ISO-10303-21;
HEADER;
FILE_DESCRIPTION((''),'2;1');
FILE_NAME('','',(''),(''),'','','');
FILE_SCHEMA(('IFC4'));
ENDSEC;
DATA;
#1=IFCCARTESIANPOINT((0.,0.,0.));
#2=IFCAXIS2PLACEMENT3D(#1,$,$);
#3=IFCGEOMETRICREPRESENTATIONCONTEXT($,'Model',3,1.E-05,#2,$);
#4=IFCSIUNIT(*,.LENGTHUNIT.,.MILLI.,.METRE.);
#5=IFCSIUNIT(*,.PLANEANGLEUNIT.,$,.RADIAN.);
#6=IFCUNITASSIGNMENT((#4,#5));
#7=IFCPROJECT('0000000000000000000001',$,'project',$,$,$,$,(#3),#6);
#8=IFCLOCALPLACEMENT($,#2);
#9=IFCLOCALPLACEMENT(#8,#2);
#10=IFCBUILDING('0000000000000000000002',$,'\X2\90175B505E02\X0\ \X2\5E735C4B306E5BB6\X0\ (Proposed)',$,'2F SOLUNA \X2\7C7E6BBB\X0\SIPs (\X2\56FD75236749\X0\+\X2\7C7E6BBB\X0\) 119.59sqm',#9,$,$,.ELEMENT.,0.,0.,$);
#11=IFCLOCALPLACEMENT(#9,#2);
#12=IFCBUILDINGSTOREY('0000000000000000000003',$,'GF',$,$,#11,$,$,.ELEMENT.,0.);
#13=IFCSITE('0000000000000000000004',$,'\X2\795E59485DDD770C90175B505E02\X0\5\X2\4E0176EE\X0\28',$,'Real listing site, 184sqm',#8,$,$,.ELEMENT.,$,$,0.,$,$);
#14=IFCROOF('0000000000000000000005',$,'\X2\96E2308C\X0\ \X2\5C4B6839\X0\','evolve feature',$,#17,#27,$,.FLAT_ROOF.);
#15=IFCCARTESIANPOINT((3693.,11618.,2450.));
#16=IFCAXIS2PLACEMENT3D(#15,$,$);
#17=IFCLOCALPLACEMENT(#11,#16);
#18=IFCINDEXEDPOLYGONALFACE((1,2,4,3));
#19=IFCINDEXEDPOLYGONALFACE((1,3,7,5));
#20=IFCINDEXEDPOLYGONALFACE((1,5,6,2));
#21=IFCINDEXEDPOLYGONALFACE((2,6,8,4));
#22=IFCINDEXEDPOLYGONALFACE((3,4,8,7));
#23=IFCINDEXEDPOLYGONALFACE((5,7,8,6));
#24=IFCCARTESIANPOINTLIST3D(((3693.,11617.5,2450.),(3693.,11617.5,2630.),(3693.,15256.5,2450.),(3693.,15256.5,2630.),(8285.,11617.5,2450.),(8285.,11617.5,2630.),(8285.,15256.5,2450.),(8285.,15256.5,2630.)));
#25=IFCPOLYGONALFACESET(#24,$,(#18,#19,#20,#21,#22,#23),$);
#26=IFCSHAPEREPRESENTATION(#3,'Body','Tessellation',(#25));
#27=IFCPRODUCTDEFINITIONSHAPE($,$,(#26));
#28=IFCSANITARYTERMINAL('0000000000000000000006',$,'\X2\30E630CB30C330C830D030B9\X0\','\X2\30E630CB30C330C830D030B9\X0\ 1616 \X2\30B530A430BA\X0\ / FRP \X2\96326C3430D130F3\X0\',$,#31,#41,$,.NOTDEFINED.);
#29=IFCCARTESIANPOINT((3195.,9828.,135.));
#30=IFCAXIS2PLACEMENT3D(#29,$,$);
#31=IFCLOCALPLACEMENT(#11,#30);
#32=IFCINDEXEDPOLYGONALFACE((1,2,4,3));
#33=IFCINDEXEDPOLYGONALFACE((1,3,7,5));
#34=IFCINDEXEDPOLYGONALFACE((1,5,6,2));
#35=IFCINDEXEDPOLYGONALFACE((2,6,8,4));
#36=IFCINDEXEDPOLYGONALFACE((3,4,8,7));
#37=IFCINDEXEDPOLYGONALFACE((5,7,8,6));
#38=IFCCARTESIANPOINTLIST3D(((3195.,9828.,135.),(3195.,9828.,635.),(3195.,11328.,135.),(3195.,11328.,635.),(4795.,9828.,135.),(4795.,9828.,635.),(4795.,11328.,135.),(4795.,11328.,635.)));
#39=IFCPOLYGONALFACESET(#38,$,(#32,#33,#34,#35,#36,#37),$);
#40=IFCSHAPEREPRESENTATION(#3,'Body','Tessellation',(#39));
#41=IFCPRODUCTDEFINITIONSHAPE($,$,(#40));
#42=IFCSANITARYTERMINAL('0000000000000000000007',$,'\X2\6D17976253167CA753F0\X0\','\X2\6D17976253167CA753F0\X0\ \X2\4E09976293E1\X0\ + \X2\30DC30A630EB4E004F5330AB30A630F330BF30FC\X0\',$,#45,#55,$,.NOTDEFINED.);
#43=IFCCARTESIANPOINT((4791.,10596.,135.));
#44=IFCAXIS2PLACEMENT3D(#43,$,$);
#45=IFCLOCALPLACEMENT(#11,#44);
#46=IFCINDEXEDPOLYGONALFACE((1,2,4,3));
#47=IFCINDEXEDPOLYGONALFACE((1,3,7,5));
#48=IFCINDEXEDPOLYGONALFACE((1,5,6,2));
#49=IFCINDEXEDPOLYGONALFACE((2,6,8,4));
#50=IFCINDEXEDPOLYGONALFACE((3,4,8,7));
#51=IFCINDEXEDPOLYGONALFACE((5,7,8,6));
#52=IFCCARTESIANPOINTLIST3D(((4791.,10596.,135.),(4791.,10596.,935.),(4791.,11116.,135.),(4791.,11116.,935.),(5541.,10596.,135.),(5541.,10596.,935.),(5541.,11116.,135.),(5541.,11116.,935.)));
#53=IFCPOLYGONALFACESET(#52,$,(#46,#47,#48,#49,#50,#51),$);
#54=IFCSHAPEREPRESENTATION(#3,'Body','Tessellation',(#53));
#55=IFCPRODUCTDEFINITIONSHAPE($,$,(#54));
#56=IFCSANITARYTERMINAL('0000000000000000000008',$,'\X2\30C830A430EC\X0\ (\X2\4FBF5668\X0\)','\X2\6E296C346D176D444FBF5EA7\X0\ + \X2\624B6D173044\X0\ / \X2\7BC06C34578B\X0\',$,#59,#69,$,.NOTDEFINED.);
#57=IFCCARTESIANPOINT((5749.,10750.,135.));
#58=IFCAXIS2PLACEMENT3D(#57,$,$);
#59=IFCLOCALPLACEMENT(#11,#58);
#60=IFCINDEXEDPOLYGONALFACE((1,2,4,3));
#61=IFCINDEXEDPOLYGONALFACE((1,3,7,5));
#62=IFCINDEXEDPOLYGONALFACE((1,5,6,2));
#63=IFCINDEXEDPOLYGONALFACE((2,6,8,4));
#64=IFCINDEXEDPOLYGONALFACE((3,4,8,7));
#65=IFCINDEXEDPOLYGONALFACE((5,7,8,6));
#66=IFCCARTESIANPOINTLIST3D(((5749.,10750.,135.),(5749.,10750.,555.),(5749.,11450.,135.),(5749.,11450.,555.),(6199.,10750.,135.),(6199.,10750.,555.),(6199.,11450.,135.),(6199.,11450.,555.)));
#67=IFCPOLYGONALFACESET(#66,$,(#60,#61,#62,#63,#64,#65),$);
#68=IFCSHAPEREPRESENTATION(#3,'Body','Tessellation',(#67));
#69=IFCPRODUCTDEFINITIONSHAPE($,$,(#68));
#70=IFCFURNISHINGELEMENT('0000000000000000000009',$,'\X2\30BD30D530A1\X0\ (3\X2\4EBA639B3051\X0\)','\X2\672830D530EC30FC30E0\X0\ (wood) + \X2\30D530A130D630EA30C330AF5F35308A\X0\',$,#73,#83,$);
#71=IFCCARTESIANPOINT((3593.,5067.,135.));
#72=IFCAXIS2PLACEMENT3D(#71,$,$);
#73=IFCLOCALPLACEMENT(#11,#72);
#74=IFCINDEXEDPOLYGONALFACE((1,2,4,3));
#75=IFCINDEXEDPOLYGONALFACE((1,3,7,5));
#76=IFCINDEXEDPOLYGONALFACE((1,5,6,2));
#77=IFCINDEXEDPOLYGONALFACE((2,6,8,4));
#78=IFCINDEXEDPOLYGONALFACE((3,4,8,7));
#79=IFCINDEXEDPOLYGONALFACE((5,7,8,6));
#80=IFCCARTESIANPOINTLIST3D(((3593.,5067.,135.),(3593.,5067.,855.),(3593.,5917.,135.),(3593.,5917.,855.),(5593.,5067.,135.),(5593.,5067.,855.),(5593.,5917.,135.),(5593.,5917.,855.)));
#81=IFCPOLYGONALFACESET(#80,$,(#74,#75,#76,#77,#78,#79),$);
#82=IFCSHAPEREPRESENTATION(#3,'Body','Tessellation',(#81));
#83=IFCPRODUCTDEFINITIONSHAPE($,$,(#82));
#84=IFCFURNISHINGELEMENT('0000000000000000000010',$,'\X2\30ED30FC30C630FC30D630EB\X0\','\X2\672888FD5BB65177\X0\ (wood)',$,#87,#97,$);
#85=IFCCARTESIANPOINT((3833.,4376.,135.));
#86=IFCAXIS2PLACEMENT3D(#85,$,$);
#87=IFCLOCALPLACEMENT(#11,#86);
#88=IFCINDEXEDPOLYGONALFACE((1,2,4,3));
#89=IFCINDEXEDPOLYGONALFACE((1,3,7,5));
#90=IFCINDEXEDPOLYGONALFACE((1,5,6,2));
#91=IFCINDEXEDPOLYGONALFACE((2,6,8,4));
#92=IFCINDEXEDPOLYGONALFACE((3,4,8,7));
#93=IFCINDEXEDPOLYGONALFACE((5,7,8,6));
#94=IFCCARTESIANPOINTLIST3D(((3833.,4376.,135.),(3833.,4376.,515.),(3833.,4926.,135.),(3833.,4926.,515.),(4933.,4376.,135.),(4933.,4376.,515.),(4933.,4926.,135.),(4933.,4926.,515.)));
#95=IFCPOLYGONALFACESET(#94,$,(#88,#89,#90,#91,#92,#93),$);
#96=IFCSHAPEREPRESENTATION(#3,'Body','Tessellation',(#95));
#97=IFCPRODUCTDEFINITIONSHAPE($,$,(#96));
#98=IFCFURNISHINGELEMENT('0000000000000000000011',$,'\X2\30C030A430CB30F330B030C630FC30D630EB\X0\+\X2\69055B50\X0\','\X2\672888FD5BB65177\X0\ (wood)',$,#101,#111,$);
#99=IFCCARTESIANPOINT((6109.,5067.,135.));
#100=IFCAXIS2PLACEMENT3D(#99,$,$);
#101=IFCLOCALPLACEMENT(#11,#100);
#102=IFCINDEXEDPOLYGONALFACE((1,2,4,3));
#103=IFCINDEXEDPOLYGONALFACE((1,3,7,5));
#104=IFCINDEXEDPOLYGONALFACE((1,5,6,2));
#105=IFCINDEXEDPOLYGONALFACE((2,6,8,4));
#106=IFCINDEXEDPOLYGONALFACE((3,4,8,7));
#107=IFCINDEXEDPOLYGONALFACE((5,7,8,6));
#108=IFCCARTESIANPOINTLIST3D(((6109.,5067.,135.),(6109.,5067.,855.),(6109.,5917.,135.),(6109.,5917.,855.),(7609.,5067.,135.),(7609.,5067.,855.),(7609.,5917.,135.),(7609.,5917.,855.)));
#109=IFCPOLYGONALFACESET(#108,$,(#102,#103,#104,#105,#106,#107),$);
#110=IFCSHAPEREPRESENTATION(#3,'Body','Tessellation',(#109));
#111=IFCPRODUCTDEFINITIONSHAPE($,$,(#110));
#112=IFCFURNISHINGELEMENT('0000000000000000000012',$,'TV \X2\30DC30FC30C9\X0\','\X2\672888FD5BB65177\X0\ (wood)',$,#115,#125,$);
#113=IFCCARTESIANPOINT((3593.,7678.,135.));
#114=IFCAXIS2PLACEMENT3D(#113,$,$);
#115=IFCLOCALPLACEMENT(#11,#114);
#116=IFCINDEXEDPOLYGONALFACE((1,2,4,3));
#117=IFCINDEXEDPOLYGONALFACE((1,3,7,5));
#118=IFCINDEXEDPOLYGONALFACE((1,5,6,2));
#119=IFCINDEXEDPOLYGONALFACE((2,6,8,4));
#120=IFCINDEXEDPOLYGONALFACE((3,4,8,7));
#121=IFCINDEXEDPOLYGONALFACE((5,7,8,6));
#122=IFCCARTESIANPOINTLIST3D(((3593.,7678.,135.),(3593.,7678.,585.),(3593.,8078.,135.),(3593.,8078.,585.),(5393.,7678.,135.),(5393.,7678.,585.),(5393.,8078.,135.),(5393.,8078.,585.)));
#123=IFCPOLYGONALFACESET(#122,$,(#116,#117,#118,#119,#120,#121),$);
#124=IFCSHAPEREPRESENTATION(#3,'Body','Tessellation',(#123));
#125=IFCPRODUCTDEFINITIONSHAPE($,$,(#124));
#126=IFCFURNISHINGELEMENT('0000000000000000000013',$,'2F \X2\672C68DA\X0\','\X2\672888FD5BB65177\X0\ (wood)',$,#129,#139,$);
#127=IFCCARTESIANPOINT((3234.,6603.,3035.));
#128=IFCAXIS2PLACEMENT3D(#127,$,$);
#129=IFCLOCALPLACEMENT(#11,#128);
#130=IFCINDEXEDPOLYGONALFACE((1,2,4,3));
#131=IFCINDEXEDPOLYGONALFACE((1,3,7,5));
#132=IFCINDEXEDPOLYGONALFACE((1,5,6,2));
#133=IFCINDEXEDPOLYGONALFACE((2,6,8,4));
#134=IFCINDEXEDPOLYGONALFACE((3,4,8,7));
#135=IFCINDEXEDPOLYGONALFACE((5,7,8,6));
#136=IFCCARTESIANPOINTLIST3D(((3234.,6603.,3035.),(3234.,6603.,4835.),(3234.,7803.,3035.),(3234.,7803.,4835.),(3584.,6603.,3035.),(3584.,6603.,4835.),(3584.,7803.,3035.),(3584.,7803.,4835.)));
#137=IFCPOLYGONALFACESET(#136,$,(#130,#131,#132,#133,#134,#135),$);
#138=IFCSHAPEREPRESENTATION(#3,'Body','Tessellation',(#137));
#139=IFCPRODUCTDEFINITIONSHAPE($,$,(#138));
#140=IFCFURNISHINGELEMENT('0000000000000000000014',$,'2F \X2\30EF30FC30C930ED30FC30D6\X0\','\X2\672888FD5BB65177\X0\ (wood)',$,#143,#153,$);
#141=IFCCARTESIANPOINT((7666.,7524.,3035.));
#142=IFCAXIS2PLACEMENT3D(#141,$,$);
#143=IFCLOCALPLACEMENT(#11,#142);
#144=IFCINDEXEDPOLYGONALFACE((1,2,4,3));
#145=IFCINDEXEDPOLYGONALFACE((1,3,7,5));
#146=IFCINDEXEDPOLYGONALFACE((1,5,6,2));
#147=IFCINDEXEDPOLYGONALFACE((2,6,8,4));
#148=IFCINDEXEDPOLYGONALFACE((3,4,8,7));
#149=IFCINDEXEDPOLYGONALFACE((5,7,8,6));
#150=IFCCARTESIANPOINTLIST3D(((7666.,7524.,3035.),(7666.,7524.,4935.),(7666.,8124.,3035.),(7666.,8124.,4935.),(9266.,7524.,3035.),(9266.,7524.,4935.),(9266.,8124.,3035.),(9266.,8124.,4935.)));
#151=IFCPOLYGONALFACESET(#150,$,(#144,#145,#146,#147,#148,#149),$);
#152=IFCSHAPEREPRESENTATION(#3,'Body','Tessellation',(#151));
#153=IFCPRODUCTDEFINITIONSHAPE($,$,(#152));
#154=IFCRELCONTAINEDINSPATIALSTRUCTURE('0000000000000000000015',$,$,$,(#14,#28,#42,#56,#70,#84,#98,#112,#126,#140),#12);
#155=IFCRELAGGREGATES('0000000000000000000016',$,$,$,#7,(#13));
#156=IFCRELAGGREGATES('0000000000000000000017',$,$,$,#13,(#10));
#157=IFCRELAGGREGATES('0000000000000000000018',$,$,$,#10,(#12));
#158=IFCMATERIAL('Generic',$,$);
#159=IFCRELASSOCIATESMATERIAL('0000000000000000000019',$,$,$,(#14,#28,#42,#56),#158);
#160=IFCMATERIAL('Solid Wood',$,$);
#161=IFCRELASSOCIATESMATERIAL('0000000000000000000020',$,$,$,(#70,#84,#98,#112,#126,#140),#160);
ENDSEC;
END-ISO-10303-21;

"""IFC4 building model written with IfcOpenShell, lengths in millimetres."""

from ifc_helpers import new_model, si_unit, frame, frame_2d, origin, place, context, project, spatial, rectangle, extrude, material, element, save


model = new_model("IFC4")

# Units and contexts
model_context = context("Model", 3, precision=1e-05, world=origin())
ifc_project = project(units=[si_unit("LENGTHUNIT", "METRE", prefix="MILLI"), si_unit("PLANEANGLEUNIT", "RADIAN")], contexts=[model_context])

# Site, building, storey
site_placement = place(None, origin())
site = spatial("IfcSite", under=ifc_project, at=site_placement, Name="神奈川県逗子市5丁目28", ObjectType="Real listing site, 184sqm", CompositionType="ELEMENT", RefElevation=0.0)
building_placement = place(site_placement, origin())
building = spatial("IfcBuilding", under=site, at=building_placement, Name="逗子市 平屋の家 (Proposed)", ObjectType="2F SOLUNA 籾殻SIPs (国産杉+籾殻) 119.59sqm", CompositionType="ELEMENT", ElevationOfRefHeight=0.0, ElevationOfTerrain=0.0)
storey_placement = place(building_placement, origin())
storey = spatial("IfcBuildingStorey", under=building, at=storey_placement, Name="GF", CompositionType="ELEMENT", Elevation=0.0)

# Shared definitions
ifc_material_1 = material(Name="Generic")

# Shared definitions
ifc_material_2 = material(Name="Solid Wood")

# Roof
roof_1_placement = place(storey_placement, frame((3693.0, 11618.0, 2450.0)))
element("IfcRoof", 1, at=roof_1_placement, inside=storey, material=ifc_material_1, Name="離れ 屋根", Description="evolve feature", PredefinedType="FLAT_ROOF", context=model_context, shape_type="SweptSolid", body=[
    extrude(rectangle(XDim=4592.0, YDim=3639.0, at=frame_2d((2296.0, 1819.0))), frame((3693.0, 11618.0, 2450.0)), (0.0, 0.0, 1.0), 180.0),
])

# Sanitary terminals
sanitary_terminal_1_placement = place(storey_placement, frame((3195.0, 9828.0, 135.0)))
element("IfcSanitaryTerminal", 2, at=sanitary_terminal_1_placement, inside=storey, material=ifc_material_1, Name="ユニットバス", Description="ユニットバス 1616 サイズ / FRP 防水パン", PredefinedType="NOTDEFINED", context=model_context, shape_type="SweptSolid", body=[
    extrude(rectangle(XDim=1600.0, YDim=1500.0, at=frame_2d((800.0, 750.0))), frame((3195.0, 9828.0, 135.0)), (0.0, 0.0, 1.0), 500.0),
])
sanitary_terminal_2_placement = place(storey_placement, frame((4791.0, 10596.0, 135.0)))
element("IfcSanitaryTerminal", 3, at=sanitary_terminal_2_placement, inside=storey, material=ifc_material_1, Name="洗面化粧台", Description="洗面化粧台 三面鏡 + ボウル一体カウンター", PredefinedType="NOTDEFINED", context=model_context, shape_type="SweptSolid", body=[
    extrude(rectangle(XDim=750.0, YDim=520.0, at=frame_2d((375.0, 260.0))), frame((4791.0, 10596.0, 135.0)), (0.0, 0.0, 1.0), 800.0),
])
sanitary_terminal_3_placement = place(storey_placement, frame((5749.0, 10750.0, 135.0)))
element("IfcSanitaryTerminal", 4, at=sanitary_terminal_3_placement, inside=storey, material=ifc_material_1, Name="トイレ (便器)", Description="温水洗浄便座 + 手洗い / 節水型", PredefinedType="NOTDEFINED", context=model_context, shape_type="SweptSolid", body=[
    extrude(rectangle(XDim=450.0, YDim=700.0, at=frame_2d((225.0, 350.0))), frame((5749.0, 10750.0, 135.0)), (0.0, 0.0, 1.0), 420.0),
])

# Furnishing elements
furnishing_1_placement = place(storey_placement, frame((3593.0, 5067.0, 135.0)))
element("IfcFurnishingElement", 5, at=furnishing_1_placement, inside=storey, material=ifc_material_2, Name="ソファ (3人掛け)", Description="木フレーム (wood) + ファブリック張り", context=model_context, shape_type="SweptSolid", body=[
    extrude(rectangle(XDim=2000.0, YDim=850.0, at=frame_2d((1000.0, 425.0))), frame((3593.0, 5067.0, 135.0)), (0.0, 0.0, 1.0), 720.0),
])
furnishing_2_placement = place(storey_placement, frame((3833.0, 4376.0, 135.0)))
element("IfcFurnishingElement", 6, at=furnishing_2_placement, inside=storey, material=ifc_material_2, Name="ローテーブル", Description="木製家具 (wood)", context=model_context, shape_type="SweptSolid", body=[
    extrude(rectangle(XDim=1100.0, YDim=550.0, at=frame_2d((550.0, 275.0))), frame((3833.0, 4376.0, 135.0)), (0.0, 0.0, 1.0), 380.0),
])
furnishing_3_placement = place(storey_placement, frame((6109.0, 5067.0, 135.0)))
element("IfcFurnishingElement", 7, at=furnishing_3_placement, inside=storey, material=ifc_material_2, Name="ダイニングテーブル+椅子", Description="木製家具 (wood)", context=model_context, shape_type="SweptSolid", body=[
    extrude(rectangle(XDim=1500.0, YDim=850.0, at=frame_2d((750.0, 425.0))), frame((6109.0, 5067.0, 135.0)), (0.0, 0.0, 1.0), 720.0),
])
furnishing_4_placement = place(storey_placement, frame((3593.0, 7678.0, 135.0)))
element("IfcFurnishingElement", 8, at=furnishing_4_placement, inside=storey, material=ifc_material_2, Name="TV ボード", Description="木製家具 (wood)", context=model_context, shape_type="SweptSolid", body=[
    extrude(rectangle(XDim=1800.0, YDim=400.0, at=frame_2d((900.0, 200.0))), frame((3593.0, 7678.0, 135.0)), (0.0, 0.0, 1.0), 450.0),
])
furnishing_5_placement = place(storey_placement, frame((3234.0, 6603.0, 3035.0)))
element("IfcFurnishingElement", 9, at=furnishing_5_placement, inside=storey, material=ifc_material_2, Name="2F 本棚", Description="木製家具 (wood)", context=model_context, shape_type="SweptSolid", body=[
    extrude(rectangle(XDim=350.0, YDim=1200.0, at=frame_2d((175.0, 600.0))), frame((3234.0, 6603.0, 3035.0)), (0.0, 0.0, 1.0), 1800.0),
])
furnishing_6_placement = place(storey_placement, frame((7666.0, 7524.0, 3035.0)))
element("IfcFurnishingElement", 10, at=furnishing_6_placement, inside=storey, material=ifc_material_2, Name="2F ワードローブ", Description="木製家具 (wood)", context=model_context, shape_type="SweptSolid", body=[
    extrude(rectangle(XDim=1600.0, YDim=600.0, at=frame_2d((800.0, 300.0))), frame((7666.0, 7524.0, 3035.0)), (0.0, 0.0, 1.0), 1900.0),
])

save(model, "model.ifc")
